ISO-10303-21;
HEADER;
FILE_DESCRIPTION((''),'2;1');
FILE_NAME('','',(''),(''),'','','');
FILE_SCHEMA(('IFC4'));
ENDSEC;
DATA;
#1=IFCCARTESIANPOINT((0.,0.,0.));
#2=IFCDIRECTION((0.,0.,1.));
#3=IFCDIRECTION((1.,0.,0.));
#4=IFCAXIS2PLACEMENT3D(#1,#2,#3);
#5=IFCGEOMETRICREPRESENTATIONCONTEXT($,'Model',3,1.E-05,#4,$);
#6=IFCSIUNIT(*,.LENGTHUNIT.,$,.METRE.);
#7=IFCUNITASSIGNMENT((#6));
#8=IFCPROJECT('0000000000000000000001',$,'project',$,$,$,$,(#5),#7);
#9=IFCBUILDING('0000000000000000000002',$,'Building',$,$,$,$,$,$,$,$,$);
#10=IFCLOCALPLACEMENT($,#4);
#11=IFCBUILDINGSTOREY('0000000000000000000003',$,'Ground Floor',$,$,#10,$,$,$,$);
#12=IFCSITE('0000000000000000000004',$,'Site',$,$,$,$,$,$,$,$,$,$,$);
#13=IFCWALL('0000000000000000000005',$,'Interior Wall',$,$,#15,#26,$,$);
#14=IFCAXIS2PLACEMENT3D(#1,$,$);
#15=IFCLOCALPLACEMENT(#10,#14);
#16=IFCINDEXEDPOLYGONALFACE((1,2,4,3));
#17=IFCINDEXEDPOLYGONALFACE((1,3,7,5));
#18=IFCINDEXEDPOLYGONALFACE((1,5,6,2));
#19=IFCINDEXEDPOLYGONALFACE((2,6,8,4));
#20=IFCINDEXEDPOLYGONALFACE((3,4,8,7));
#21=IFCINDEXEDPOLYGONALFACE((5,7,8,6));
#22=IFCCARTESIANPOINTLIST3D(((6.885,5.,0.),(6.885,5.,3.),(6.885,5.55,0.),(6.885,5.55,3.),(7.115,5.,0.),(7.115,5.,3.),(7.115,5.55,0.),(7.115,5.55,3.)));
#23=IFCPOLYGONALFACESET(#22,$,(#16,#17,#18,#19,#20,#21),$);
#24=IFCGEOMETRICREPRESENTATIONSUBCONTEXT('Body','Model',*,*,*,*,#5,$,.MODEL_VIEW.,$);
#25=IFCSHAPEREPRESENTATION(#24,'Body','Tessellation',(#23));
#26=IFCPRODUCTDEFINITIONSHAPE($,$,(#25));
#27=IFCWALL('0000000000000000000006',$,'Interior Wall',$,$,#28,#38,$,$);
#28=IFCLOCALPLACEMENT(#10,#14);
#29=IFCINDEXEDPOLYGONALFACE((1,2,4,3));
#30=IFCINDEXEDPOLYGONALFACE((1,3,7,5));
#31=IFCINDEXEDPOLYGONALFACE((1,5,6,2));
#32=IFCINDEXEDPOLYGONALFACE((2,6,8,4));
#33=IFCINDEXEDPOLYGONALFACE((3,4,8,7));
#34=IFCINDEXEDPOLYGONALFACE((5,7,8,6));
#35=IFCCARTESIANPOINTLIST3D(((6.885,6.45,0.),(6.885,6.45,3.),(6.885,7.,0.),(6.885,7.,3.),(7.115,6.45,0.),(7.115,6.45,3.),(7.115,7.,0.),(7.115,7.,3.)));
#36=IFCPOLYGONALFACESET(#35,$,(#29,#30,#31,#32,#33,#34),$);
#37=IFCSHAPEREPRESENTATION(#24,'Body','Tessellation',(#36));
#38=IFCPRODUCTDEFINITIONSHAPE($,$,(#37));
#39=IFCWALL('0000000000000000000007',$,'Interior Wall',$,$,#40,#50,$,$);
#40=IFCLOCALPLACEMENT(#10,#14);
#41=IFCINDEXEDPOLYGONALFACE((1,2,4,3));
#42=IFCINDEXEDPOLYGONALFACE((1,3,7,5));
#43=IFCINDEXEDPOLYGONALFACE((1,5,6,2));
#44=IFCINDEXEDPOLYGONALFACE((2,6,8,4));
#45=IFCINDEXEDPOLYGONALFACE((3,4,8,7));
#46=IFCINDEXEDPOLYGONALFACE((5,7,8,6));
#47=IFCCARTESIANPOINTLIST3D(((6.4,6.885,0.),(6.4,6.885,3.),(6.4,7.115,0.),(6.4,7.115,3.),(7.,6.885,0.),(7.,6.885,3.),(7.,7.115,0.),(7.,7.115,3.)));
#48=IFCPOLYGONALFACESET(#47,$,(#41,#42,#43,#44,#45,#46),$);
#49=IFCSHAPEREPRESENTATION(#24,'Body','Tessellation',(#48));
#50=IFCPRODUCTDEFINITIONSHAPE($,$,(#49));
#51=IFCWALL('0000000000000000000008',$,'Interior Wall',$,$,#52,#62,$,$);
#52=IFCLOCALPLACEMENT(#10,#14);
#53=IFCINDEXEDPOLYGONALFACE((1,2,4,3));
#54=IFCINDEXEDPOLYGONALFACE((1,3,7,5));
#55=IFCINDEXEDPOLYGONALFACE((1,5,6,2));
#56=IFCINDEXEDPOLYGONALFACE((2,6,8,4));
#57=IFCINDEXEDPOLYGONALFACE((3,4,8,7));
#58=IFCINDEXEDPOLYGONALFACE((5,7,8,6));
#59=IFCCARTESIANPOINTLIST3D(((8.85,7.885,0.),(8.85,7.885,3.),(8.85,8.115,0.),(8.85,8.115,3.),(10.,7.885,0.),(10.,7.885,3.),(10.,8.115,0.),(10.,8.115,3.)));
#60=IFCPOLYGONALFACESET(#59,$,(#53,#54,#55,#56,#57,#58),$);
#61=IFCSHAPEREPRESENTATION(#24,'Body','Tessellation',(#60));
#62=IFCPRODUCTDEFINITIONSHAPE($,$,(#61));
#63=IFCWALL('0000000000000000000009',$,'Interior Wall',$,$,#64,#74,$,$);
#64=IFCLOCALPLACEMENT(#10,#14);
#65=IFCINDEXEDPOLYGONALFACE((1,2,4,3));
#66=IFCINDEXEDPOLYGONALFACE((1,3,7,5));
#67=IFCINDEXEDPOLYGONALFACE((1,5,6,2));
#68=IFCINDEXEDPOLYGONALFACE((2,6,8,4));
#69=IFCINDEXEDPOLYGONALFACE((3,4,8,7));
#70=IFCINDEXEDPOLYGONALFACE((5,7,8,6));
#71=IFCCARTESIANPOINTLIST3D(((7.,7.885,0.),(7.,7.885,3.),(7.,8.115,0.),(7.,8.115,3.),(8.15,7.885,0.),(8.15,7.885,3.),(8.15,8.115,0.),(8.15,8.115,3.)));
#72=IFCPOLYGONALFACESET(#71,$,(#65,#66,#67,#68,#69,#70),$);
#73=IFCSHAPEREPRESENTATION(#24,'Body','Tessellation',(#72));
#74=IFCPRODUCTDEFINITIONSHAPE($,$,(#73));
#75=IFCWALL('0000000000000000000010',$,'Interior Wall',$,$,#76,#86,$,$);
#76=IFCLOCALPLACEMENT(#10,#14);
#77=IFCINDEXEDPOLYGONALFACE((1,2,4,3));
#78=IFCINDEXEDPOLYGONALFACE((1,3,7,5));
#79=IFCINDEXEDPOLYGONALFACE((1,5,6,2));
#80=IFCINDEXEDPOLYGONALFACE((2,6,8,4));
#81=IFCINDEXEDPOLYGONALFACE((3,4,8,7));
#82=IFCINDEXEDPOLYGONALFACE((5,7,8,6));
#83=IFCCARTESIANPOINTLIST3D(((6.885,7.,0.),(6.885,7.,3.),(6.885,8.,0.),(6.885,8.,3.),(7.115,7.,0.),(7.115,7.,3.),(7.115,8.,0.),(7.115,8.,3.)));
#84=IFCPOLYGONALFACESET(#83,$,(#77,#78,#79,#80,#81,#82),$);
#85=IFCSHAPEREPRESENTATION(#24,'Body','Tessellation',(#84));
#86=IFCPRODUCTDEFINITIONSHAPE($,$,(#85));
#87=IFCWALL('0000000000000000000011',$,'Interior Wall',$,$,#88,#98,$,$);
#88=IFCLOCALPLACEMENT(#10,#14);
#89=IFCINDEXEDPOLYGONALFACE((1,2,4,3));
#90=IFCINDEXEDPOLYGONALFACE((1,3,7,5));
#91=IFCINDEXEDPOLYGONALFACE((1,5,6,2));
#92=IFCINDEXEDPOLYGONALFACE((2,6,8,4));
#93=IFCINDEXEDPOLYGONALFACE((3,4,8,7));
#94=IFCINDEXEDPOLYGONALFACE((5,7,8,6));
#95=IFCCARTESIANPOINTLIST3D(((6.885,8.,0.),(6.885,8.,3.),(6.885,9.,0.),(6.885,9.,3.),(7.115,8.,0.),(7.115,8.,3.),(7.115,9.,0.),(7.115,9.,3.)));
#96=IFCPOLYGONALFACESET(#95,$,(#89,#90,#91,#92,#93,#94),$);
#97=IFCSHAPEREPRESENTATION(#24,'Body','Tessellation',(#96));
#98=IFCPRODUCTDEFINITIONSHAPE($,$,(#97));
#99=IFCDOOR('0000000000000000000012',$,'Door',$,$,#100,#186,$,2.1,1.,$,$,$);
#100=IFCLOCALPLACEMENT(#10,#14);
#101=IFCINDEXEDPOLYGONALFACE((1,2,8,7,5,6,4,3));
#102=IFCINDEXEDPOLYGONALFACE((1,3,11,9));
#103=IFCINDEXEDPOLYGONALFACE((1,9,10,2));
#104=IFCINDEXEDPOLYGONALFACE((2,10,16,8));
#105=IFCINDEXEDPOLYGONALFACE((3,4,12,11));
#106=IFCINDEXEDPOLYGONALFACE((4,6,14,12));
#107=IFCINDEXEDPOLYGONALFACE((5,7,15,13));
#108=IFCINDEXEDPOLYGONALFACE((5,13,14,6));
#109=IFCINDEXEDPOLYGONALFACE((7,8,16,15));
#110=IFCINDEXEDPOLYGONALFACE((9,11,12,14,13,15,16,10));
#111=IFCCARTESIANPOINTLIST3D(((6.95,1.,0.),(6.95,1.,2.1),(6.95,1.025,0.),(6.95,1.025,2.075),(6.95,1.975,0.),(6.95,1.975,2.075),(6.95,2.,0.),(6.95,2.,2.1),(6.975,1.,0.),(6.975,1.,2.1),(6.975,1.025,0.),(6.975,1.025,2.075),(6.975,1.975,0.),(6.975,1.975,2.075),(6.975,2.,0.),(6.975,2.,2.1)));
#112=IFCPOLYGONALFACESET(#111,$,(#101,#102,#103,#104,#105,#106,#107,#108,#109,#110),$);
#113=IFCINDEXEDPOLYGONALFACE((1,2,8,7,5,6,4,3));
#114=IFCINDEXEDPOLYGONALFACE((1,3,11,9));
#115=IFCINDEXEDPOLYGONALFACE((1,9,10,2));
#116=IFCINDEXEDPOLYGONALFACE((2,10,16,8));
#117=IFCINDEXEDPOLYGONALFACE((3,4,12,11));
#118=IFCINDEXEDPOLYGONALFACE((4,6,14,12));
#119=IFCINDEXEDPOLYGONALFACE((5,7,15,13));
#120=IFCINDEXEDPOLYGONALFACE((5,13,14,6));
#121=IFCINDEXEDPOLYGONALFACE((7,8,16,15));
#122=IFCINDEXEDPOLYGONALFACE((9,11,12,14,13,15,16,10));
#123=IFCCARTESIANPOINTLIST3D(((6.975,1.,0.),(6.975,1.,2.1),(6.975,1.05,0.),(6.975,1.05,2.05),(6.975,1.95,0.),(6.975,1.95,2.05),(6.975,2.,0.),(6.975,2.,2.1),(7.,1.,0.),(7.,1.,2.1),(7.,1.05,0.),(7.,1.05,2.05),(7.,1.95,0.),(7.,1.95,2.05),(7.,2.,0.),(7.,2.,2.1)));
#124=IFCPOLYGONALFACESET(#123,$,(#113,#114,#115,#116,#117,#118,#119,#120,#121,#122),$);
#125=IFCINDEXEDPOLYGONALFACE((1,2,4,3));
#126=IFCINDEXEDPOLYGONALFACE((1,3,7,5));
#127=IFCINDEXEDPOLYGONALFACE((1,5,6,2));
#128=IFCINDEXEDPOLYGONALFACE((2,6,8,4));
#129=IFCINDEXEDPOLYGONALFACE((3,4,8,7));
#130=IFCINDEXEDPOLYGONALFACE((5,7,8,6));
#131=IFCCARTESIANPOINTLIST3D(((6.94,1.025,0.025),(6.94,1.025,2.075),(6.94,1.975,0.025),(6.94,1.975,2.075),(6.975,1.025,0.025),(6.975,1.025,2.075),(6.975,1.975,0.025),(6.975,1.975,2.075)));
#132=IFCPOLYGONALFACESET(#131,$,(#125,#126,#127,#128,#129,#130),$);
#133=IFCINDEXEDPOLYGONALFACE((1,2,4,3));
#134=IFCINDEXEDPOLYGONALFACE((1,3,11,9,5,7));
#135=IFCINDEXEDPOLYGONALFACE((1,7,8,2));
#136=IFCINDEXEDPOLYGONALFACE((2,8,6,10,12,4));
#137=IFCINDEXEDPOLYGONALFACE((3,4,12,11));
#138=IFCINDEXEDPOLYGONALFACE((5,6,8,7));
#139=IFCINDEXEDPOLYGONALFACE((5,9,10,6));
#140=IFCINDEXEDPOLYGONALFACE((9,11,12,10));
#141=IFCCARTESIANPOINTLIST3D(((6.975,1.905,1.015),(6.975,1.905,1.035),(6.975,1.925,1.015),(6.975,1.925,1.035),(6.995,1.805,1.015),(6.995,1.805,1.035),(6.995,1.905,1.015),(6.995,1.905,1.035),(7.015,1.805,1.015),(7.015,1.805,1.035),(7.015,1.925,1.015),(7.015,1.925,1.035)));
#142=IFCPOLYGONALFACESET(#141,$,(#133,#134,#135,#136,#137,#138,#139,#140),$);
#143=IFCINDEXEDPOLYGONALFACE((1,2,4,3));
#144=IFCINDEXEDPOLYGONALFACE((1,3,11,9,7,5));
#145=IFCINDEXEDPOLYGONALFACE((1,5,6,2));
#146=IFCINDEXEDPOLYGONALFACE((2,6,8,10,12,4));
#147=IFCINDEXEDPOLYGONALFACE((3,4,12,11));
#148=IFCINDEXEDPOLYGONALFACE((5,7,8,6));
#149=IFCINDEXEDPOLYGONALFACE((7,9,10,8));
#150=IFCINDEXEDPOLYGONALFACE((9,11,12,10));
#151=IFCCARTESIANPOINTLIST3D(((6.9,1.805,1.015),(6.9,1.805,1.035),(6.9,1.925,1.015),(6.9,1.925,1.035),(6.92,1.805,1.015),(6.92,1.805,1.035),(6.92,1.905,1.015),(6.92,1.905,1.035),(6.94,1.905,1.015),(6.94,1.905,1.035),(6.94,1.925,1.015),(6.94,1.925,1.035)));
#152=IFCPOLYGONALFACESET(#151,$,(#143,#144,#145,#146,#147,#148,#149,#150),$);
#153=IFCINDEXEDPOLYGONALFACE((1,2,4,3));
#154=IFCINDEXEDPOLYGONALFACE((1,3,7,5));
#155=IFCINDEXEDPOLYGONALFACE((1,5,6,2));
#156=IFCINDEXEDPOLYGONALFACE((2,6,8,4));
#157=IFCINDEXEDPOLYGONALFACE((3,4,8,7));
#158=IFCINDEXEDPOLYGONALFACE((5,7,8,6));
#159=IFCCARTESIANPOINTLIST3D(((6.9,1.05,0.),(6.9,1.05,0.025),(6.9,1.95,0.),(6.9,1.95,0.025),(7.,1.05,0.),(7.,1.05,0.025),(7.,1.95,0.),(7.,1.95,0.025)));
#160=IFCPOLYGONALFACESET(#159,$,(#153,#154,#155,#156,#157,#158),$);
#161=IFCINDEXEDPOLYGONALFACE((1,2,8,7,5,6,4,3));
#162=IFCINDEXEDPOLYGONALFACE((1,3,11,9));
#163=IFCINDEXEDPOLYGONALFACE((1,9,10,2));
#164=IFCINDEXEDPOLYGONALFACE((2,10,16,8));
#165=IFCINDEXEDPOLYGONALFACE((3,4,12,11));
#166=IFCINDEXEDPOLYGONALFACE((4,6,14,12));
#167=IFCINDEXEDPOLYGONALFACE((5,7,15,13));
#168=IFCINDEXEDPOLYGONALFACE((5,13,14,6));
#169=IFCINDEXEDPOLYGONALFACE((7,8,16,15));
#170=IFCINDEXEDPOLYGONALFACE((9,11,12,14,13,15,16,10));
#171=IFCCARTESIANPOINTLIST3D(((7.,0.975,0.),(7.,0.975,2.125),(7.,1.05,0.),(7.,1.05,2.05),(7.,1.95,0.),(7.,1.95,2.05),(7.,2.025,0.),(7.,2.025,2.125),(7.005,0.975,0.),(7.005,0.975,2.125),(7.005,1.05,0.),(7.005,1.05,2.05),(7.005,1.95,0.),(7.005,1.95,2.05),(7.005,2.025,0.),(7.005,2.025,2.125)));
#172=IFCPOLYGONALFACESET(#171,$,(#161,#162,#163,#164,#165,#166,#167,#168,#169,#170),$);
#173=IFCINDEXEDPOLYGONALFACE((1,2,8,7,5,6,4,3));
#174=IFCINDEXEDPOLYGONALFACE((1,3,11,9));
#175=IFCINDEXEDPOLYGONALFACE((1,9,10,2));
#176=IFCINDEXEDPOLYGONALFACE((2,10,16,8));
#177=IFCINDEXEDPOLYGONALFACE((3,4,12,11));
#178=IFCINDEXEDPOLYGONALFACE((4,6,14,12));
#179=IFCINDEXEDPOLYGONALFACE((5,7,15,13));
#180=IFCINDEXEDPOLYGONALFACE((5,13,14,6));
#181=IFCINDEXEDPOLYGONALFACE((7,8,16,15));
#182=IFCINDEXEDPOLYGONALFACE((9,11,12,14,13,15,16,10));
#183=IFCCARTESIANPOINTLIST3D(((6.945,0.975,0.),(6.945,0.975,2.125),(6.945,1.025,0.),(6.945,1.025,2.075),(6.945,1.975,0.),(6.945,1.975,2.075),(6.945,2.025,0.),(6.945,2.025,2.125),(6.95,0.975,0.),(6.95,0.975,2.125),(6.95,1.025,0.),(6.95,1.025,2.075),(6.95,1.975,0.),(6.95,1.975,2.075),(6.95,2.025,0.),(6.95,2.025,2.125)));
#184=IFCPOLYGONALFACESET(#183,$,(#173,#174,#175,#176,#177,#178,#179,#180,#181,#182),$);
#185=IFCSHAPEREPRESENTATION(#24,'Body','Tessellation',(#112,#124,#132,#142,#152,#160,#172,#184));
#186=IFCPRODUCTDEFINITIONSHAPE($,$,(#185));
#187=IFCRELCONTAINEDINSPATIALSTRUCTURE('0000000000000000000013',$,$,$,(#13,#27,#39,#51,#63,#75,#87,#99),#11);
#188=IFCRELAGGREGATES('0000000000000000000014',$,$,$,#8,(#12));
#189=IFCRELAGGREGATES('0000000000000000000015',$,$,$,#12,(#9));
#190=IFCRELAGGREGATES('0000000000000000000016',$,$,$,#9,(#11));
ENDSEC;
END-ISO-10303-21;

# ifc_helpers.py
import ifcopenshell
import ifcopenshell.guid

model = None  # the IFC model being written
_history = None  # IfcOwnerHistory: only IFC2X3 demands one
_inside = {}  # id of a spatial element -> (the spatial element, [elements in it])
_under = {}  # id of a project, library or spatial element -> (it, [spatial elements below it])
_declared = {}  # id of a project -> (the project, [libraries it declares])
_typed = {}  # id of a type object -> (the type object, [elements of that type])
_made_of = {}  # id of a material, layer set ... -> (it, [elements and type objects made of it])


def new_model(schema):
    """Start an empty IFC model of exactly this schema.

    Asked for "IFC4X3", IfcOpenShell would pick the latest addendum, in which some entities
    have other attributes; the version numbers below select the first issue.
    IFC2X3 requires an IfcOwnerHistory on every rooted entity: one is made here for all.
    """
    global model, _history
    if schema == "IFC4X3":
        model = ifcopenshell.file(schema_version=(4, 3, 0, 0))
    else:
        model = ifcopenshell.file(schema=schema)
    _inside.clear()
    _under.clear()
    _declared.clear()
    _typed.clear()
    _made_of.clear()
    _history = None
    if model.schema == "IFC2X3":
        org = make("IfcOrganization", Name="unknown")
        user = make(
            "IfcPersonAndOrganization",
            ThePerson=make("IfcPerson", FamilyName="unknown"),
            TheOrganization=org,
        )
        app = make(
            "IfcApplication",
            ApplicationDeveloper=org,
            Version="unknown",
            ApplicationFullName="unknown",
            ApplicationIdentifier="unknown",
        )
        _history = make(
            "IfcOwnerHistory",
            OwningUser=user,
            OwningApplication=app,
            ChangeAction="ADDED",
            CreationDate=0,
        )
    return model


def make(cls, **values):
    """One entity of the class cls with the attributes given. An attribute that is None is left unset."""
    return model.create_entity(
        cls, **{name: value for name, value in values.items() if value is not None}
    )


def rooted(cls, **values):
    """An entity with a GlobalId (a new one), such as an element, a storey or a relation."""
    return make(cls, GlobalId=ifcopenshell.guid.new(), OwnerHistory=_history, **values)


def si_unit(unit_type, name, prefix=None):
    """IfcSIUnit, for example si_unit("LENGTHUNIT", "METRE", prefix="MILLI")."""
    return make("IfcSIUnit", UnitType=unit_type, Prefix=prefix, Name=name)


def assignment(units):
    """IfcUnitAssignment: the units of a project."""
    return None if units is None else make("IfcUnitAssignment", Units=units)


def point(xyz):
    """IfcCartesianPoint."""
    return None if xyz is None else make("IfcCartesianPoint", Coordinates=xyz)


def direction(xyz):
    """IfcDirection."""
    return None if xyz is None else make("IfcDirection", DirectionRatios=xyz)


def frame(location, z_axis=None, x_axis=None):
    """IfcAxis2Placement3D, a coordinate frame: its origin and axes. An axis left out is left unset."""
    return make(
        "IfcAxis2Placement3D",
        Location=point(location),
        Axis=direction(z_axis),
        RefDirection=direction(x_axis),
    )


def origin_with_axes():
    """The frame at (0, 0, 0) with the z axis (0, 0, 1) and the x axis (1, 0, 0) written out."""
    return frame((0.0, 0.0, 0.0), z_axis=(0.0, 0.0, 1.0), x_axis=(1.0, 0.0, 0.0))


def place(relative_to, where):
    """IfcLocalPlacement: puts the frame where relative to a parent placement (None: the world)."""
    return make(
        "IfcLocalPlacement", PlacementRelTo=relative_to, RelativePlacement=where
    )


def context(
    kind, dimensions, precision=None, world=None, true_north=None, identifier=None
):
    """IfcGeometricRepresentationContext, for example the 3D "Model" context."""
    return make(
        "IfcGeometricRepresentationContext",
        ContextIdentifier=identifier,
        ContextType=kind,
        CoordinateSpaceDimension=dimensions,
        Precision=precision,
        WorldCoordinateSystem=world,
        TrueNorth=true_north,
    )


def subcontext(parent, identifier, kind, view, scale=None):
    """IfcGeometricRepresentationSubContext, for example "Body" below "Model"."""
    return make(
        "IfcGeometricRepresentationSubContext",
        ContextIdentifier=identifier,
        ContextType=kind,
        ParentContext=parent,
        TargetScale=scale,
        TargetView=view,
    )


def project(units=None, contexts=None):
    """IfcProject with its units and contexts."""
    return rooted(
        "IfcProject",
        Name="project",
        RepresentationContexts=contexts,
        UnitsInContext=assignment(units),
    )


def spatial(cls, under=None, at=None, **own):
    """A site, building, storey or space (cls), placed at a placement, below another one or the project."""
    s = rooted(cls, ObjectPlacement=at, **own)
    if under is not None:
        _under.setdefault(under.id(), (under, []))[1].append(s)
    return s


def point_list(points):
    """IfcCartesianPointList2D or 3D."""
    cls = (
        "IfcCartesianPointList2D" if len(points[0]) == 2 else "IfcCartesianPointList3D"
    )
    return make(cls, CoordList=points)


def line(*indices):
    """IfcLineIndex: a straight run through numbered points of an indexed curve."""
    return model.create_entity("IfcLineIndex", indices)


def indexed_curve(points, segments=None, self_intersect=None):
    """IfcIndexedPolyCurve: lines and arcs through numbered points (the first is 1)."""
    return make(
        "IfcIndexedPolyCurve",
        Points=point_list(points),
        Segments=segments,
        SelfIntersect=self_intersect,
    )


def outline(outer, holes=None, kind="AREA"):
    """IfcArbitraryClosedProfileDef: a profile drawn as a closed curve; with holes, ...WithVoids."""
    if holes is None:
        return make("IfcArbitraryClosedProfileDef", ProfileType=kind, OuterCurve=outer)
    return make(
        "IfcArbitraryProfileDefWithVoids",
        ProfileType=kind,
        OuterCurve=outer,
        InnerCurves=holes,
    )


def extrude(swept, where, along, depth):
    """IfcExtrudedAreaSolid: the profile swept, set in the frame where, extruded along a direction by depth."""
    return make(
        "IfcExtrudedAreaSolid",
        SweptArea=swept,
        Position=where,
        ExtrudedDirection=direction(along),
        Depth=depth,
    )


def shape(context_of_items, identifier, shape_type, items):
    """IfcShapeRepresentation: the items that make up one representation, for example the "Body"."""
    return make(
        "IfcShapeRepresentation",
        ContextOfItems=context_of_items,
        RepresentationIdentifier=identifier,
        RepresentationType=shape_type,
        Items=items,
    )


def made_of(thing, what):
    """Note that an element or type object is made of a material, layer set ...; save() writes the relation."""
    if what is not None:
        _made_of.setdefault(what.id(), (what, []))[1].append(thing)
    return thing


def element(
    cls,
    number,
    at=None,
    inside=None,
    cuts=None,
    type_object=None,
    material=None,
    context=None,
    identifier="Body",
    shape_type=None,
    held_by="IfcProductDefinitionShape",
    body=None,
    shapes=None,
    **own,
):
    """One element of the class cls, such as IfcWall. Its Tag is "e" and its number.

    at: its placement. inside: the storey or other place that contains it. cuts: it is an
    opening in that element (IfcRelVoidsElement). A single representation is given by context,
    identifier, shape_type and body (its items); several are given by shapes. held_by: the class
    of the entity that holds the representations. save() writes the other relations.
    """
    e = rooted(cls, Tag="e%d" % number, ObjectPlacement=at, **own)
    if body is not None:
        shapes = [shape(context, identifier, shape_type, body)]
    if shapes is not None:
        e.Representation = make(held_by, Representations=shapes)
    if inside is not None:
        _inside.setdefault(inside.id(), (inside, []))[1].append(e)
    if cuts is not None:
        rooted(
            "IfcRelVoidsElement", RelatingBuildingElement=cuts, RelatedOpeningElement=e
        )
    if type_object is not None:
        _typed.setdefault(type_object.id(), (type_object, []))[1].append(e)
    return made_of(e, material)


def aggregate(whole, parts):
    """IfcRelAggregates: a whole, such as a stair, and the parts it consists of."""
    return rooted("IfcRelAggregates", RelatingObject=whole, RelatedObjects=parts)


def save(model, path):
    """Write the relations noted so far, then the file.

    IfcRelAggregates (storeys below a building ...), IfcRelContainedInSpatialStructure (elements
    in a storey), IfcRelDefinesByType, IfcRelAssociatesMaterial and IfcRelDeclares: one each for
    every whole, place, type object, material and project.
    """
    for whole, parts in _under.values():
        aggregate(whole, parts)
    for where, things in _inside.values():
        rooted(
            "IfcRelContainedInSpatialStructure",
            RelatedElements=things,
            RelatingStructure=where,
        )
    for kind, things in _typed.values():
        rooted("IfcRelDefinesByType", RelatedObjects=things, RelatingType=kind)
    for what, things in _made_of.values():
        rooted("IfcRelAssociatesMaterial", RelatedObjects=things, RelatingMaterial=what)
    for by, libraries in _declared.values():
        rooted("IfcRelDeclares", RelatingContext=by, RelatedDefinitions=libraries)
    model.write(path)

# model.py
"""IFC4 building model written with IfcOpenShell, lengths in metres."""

from ifc_helpers import new_model, si_unit, frame, origin_with_axes, place, context, subcontext, project, spatial, line, indexed_curve, outline, extrude, element, save


model = new_model("IFC4")

# Units and contexts
model_context = context("Model", 3, precision=1e-05, world=origin_with_axes())
body_context = subcontext(model_context, "Body", "Model", "MODEL_VIEW")
ifc_project = project(units=[si_unit("LENGTHUNIT", "METRE")], contexts=[model_context])

# Site, building, storey
site = spatial("IfcSite", under=ifc_project, Name="Site")
building = spatial("IfcBuilding", under=site, Name="Building")
storey_placement = place(None, origin_with_axes())
storey = spatial("IfcBuildingStorey", under=building, at=storey_placement, Name="Ground Floor")

# Walls
for number, where, z_axis, x_axis, name in (
    (1, (7.0, 5.0, 0.0), (0.0, 0.0, 1.0), (0.0, 1.0, 0.0), "Interior Wall"),
    (2, (7.0, 6.45, 0.0), (0.0, 0.0, 1.0), (0.0, 1.0, 0.0), "Interior Wall"),
):
    element("IfcWall", number, at=place(storey_placement, frame(where, z_axis=z_axis, x_axis=x_axis)), inside=storey, Name=name, context=body_context, shape_type="SweptSolid", body=[
        extrude(outline(indexed_curve([(0.0, 0.0), (0.0, 0.23), (0.55, 0.23), (0.55, 0.0), (0.0, 0.0)], self_intersect=False)), frame((0.0, -0.115, 0.0), z_axis=(0.0, 0.0, 1.0), x_axis=(1.0, 0.0, 0.0)), (0.0, 0.0, 1.0), 3.0),
    ])
wall_1_placement = place(storey_placement, frame((7.0, 7.0, 0.0), z_axis=(0.0, 0.0, 1.0), x_axis=(-1.0, 0.0, 0.0)))
element("IfcWall", 3, at=wall_1_placement, inside=storey, Name="Interior Wall", context=body_context, shape_type="SweptSolid", body=[
    extrude(outline(indexed_curve([(0.0, 0.0), (0.0, 0.23), (0.6, 0.23), (0.6, 0.0), (0.0, 0.0)], self_intersect=False)), frame((0.0, -0.115, 0.0), z_axis=(0.0, 0.0, 1.0), x_axis=(1.0, 0.0, 0.0)), (0.0, 0.0, 1.0), 3.0),
])
for number, where, z_axis, x_axis, name in (
    (4, (10.0, 8.0, 0.0), (0.0, 0.0, 1.0), (-1.0, 0.0, 0.0), "Interior Wall"),
    (5, (8.15, 8.0, 0.0), (0.0, 0.0, 1.0), (-1.0, 0.0, 0.0), "Interior Wall"),
):
    element("IfcWall", number, at=place(storey_placement, frame(where, z_axis=z_axis, x_axis=x_axis)), inside=storey, Name=name, context=body_context, shape_type="SweptSolid", body=[
        extrude(outline(indexed_curve([(0.0, 0.0), (0.0, 0.23), (1.15, 0.23), (1.15, 0.0), (0.0, 0.0)], self_intersect=False)), frame((0.0, -0.115, 0.0), z_axis=(0.0, 0.0, 1.0), x_axis=(1.0, 0.0, 0.0)), (0.0, 0.0, 1.0), 3.0),
    ])
for number, where, z_axis, x_axis, name in (
    (6, (7.0, 8.0, 0.0), (0.0, 0.0, 1.0), (0.0, -1.0, 0.0), "Interior Wall"),
    (7, (7.0, 8.0, 0.0), (0.0, 0.0, 1.0), (0.0, 1.0, 0.0), "Interior Wall"),
):
    element("IfcWall", number, at=place(storey_placement, frame(where, z_axis=z_axis, x_axis=x_axis)), inside=storey, Name=name, context=body_context, shape_type="SweptSolid", body=[
        extrude(outline(indexed_curve([(0.0, 0.0), (0.0, 0.23), (1.0, 0.23), (1.0, 0.0), (0.0, 0.0)], self_intersect=False)), frame((0.0, -0.115, 0.0), z_axis=(0.0, 0.0, 1.0), x_axis=(1.0, 0.0, 0.0)), (0.0, 0.0, 1.0), 3.0),
    ])

# Door
door_1_placement = place(storey_placement, frame((7.0, 1.0, 0.0), z_axis=(0.0, 0.0, 1.0), x_axis=(0.0, 1.0, 0.0)))
element("IfcDoor", 8, at=door_1_placement, inside=storey, Name="Door", OverallHeight=2.1, OverallWidth=1.0, context=body_context, shape_type="SweptSolid", body=[
    extrude(outline(indexed_curve([(0.0, 0.0), (0.0, 2.1), (1.0, 2.1), (1.0, 0.0), (0.975, 0.0), (0.975, 2.075), (0.025, 2.075), (0.025, 0.0)], segments=[line(1, 2, 3, 4, 5, 6, 7, 8, 1)])), frame((0.0, 0.025, 0.0), z_axis=(0.0, -1.0, 0.0), x_axis=(1.0, 0.0, 0.0)), (0.0, 0.0, -1.0), 0.025),
    extrude(outline(indexed_curve([(0.0, 0.0), (0.0, 2.1), (1.0, 2.1), (1.0, 0.0), (0.95, 0.0), (0.95, 2.05), (0.05, 2.05), (0.05, 0.0)], segments=[line(1, 2, 3, 4, 5, 6, 7, 8, 1)])), frame((0.0, 0.0, 0.0), z_axis=(0.0, -1.0, 0.0), x_axis=(1.0, 0.0, 0.0)), (0.0, 0.0, -1.0), 0.025),
    extrude(outline(indexed_curve([(0.0, 0.0), (0.95, 0.0), (0.95, 0.035), (0.0, 0.035)], segments=[line(1, 2, 3, 4, 1)])), frame((0.025, 0.025, 0.025), z_axis=(0.0, 0.0, 1.0), x_axis=(1.0, 0.0, 0.0)), (0.0, 0.0, 1.0), 2.05),
    extrude(outline(indexed_curve([(0.0, 0.0), (0.0, -0.04), (-0.12, -0.04), (-0.12, -0.02), (-0.02, -0.02), (-0.02, 0.0)], segments=[line(1, 2, 3, 4, 5, 6, 1)])), frame((0.925, 0.025, 1.015), z_axis=(0.0, 0.0, 1.0), x_axis=(1.0, 0.0, 0.0)), (0.0, 0.0, 1.0), 0.02),
    extrude(outline(indexed_curve([(0.0, 0.0), (0.0, 0.04), (-0.12, 0.04), (-0.12, 0.02), (-0.02, 0.02), (-0.02, 0.0)], segments=[line(1, 2, 3, 4, 5, 6, 1)])), frame((0.925, 0.06, 1.015), z_axis=(0.0, 0.0, 1.0), x_axis=(1.0, 0.0, 0.0)), (0.0, 0.0, 1.0), 0.02),
    extrude(outline(indexed_curve([(0.0, 0.0), (0.9, 0.0), (0.9, 0.1), (0.0, 0.1)], segments=[line(1, 2, 3, 4, 1)])), frame((0.05, 0.0, 0.0), z_axis=(0.0, 0.0, 1.0), x_axis=(1.0, 0.0, 0.0)), (0.0, 0.0, 1.0), 0.025),
    extrude(outline(indexed_curve([(0.0, 0.0), (0.0, 2.125), (1.05, 2.125), (1.05, 0.0), (0.975, 0.0), (0.975, 2.05), (0.075, 2.05), (0.075, 0.0)], segments=[line(1, 2, 3, 4, 5, 6, 7, 8, 1)])), frame((-0.025, -0.005, 0.0), z_axis=(0.0, -1.0, 0.0), x_axis=(1.0, 0.0, 0.0)), (0.0, 0.0, -1.0), 0.005),
    extrude(outline(indexed_curve([(0.0, 0.0), (0.0, 2.125), (1.05, 2.125), (1.05, 0.0), (1.0, 0.0), (1.0, 2.075), (0.05, 2.075), (0.05, 0.0)], segments=[line(1, 2, 3, 4, 5, 6, 7, 8, 1)])), frame((-0.025, 0.05, 0.0), z_axis=(0.0, -1.0, 0.0), x_axis=(1.0, 0.0, 0.0)), (0.0, 0.0, -1.0), 0.005),
])

save(model, "model.ifc")
